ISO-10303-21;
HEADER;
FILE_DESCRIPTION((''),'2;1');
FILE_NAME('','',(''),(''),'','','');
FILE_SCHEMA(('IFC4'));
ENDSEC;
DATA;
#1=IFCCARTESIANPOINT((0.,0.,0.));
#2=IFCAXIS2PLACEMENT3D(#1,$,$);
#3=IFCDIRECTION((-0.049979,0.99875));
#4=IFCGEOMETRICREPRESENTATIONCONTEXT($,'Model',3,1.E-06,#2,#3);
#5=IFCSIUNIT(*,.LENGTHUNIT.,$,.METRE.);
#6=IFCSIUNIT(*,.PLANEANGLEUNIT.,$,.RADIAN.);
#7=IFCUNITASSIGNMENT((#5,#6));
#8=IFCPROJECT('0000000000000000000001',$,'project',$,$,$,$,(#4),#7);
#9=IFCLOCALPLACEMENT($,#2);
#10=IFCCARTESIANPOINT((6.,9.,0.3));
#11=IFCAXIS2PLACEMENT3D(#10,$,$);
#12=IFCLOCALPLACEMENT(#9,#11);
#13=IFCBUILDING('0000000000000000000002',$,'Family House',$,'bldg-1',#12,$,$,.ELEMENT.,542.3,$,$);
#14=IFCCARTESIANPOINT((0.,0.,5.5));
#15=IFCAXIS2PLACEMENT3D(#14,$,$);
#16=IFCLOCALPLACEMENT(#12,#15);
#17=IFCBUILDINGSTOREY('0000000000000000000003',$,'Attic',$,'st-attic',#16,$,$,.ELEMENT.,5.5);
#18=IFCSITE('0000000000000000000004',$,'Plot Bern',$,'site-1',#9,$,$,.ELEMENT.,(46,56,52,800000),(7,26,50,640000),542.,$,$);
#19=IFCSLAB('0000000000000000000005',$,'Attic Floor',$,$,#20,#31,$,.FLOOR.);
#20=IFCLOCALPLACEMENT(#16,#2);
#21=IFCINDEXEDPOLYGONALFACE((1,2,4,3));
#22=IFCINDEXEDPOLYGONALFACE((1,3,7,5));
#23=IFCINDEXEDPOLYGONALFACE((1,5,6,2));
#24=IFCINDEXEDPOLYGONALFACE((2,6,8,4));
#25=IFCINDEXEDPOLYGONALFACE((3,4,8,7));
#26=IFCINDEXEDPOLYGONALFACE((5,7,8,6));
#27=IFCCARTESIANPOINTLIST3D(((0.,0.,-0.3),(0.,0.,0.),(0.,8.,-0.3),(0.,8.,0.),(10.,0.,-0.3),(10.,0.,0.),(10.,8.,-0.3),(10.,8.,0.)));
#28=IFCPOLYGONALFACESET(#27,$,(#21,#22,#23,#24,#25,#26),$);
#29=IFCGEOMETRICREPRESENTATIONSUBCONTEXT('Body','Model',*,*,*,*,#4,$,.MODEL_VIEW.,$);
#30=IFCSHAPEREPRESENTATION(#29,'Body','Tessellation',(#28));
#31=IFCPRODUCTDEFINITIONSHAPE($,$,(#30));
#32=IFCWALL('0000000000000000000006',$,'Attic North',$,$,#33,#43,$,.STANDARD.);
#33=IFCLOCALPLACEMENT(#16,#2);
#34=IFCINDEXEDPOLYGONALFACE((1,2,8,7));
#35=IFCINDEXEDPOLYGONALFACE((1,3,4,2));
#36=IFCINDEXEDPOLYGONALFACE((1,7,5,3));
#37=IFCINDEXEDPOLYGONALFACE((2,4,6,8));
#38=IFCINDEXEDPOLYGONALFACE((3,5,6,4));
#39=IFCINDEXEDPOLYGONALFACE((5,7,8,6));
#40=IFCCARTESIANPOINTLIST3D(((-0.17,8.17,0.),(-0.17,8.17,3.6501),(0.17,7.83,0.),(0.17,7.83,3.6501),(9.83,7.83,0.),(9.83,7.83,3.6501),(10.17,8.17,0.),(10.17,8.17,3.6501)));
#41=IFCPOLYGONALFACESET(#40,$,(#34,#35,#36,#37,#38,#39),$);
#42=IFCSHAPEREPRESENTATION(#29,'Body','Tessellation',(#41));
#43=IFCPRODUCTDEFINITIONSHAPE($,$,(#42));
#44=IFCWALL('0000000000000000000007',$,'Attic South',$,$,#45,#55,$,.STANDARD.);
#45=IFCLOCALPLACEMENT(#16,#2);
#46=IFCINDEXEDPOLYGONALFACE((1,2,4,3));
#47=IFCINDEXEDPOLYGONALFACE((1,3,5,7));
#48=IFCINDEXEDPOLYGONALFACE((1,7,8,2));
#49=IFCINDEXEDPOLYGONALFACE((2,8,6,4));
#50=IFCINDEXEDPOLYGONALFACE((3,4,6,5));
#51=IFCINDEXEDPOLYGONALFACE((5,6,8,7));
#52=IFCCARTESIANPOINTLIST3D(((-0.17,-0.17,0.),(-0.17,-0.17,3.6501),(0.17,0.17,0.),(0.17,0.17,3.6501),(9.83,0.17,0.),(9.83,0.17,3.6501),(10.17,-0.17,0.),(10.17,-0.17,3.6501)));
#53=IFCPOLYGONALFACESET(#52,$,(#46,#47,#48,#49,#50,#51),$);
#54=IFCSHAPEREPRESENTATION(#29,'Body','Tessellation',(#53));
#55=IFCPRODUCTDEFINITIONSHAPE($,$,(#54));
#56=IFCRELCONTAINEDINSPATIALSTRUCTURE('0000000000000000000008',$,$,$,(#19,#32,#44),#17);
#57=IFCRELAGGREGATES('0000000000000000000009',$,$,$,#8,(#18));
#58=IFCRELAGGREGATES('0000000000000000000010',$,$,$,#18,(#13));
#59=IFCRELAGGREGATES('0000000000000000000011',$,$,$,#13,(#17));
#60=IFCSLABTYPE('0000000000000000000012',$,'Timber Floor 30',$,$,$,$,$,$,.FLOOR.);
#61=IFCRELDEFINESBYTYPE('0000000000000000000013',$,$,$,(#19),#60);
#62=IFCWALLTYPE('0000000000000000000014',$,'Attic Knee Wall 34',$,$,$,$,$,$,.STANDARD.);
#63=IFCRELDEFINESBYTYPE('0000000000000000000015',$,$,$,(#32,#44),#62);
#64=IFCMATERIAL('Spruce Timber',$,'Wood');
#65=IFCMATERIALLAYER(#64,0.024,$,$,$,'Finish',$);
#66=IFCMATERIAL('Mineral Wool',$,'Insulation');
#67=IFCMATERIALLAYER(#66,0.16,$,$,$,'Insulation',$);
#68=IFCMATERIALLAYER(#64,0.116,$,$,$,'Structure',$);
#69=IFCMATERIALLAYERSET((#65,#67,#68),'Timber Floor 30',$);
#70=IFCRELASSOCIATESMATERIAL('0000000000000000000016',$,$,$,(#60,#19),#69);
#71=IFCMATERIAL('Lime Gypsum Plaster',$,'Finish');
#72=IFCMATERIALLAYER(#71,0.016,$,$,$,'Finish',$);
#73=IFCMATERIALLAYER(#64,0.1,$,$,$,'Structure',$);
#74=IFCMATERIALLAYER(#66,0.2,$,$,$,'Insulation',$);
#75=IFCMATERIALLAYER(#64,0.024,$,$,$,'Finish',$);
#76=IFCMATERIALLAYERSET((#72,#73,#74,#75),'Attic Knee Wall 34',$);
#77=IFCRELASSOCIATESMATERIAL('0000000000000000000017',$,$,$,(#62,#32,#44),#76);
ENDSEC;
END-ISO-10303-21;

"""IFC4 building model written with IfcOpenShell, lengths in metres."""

from ifc_helpers import new_model, si_unit, direction, frame, origin, place, context, subcontext, project, spatial, polyline, outline, extrude, material, layer, layer_set, layer_usage, type_object, element, save


model = new_model("IFC4")

# Units and contexts
model_context = context("Model", 3, precision=1e-06, world=origin(), true_north=direction((-0.049979, 0.99875)))
body_context = subcontext(model_context, "Body", "Model", "MODEL_VIEW")
ifc_project = project(units=[si_unit("LENGTHUNIT", "METRE"), si_unit("PLANEANGLEUNIT", "RADIAN")], contexts=[model_context])

# Site, building, storey
site_placement = place(None, origin())
site = spatial("IfcSite", under=ifc_project, at=site_placement, Name="Plot Bern", ObjectType="site-1", CompositionType="ELEMENT", RefLatitude=(46, 56, 52, 800000), RefLongitude=(7, 26, 50, 640000), RefElevation=542.0)
building_placement = place(site_placement, frame((6.0, 9.0, 0.3)))
building = spatial("IfcBuilding", under=site, at=building_placement, Name="Family House", ObjectType="bldg-1", CompositionType="ELEMENT", ElevationOfRefHeight=542.3)
storey_placement = place(building_placement, frame((0.0, 0.0, 5.5)))
storey = spatial("IfcBuildingStorey", under=building, at=storey_placement, Name="Attic", ObjectType="st-attic", CompositionType="ELEMENT", Elevation=5.5)

# Slab
ifc_material_1 = material(Name="Spruce Timber", Category="Wood")
ifc_layer_1 = layer(ifc_material_1, 0.024, Category="Finish")
ifc_material_2 = material(Name="Mineral Wool", Category="Insulation")
ifc_layer_2 = layer(ifc_material_2, 0.16, Category="Insulation")
ifc_layer_3 = layer(ifc_material_1, 0.116, Category="Structure")
ifc_layer_set_1 = layer_set([ifc_layer_1, ifc_layer_2, ifc_layer_3], Name="Timber Floor 30")
ifc_layer_usage_1 = layer_usage(ifc_layer_set_1, "AXIS3", "NEGATIVE", 0.3)
slab_type = type_object("IfcSlabType", Name="Timber Floor 30", PredefinedType="FLOOR", material=ifc_layer_set_1)
slab_placement = place(storey_placement, frame((0.0, 0.0, -0.3)))
element("IfcSlab", 1, at=slab_placement, inside=storey, type_object=slab_type, material=ifc_layer_usage_1, Name="Attic Floor", PredefinedType="FLOOR", context=body_context, shape_type="SweptSolid", body=[
    extrude(outline(polyline([(0.0, 0.0), (10.0, 0.0), (10.0, 8.0), (0.0, 8.0), (0.0, 0.0)])), origin(), (0.0, 0.0, 1.0), 0.3),
])

# Walls
ifc_material_3 = material(Name="Lime Gypsum Plaster", Category="Finish")
ifc_layer_4 = layer(ifc_material_3, 0.016, Category="Finish")
ifc_layer_5 = layer(ifc_material_1, 0.1, Category="Structure")
ifc_layer_6 = layer(ifc_material_2, 0.2, Category="Insulation")
ifc_layer_7 = layer(ifc_material_1, 0.024, Category="Finish")
ifc_layer_set_2 = layer_set([ifc_layer_4, ifc_layer_5, ifc_layer_6, ifc_layer_7], Name="Attic Knee Wall 34")
ifc_layer_usage_2 = layer_usage(ifc_layer_set_2, "AXIS2", "NEGATIVE", 0.17)
wall_type = type_object("IfcWallType", Name="Attic Knee Wall 34", PredefinedType="STANDARD", material=ifc_layer_set_2)
wall_1_placement = place(storey_placement, origin())
element("IfcWall", 2, at=wall_1_placement, inside=storey, type_object=wall_type, material=ifc_layer_usage_2, Name="Attic North", PredefinedType="STANDARD", context=body_context, shape_type="SweptSolid", body=[
    extrude(outline(polyline([(10.17, 8.17), (-0.17, 8.17), (0.17, 7.83), (9.83, 7.83), (10.17, 8.17)])), origin(), (0.0, 0.0, 1.0), 3.6501),
])
ifc_layer_usage_3 = layer_usage(ifc_layer_set_2, "AXIS2", "NEGATIVE", 0.17)
wall_2_placement = place(storey_placement, origin())
element("IfcWall", 3, at=wall_2_placement, inside=storey, type_object=wall_type, material=ifc_layer_usage_3, Name="Attic South", PredefinedType="STANDARD", context=body_context, shape_type="SweptSolid", body=[
    extrude(outline(polyline([(-0.17, -0.17), (10.17, -0.17), (9.83, 0.17), (0.17, 0.17), (-0.17, -0.17)])), origin(), (0.0, 0.0, 1.0), 3.6501),
])

save(model, "model.ifc")
